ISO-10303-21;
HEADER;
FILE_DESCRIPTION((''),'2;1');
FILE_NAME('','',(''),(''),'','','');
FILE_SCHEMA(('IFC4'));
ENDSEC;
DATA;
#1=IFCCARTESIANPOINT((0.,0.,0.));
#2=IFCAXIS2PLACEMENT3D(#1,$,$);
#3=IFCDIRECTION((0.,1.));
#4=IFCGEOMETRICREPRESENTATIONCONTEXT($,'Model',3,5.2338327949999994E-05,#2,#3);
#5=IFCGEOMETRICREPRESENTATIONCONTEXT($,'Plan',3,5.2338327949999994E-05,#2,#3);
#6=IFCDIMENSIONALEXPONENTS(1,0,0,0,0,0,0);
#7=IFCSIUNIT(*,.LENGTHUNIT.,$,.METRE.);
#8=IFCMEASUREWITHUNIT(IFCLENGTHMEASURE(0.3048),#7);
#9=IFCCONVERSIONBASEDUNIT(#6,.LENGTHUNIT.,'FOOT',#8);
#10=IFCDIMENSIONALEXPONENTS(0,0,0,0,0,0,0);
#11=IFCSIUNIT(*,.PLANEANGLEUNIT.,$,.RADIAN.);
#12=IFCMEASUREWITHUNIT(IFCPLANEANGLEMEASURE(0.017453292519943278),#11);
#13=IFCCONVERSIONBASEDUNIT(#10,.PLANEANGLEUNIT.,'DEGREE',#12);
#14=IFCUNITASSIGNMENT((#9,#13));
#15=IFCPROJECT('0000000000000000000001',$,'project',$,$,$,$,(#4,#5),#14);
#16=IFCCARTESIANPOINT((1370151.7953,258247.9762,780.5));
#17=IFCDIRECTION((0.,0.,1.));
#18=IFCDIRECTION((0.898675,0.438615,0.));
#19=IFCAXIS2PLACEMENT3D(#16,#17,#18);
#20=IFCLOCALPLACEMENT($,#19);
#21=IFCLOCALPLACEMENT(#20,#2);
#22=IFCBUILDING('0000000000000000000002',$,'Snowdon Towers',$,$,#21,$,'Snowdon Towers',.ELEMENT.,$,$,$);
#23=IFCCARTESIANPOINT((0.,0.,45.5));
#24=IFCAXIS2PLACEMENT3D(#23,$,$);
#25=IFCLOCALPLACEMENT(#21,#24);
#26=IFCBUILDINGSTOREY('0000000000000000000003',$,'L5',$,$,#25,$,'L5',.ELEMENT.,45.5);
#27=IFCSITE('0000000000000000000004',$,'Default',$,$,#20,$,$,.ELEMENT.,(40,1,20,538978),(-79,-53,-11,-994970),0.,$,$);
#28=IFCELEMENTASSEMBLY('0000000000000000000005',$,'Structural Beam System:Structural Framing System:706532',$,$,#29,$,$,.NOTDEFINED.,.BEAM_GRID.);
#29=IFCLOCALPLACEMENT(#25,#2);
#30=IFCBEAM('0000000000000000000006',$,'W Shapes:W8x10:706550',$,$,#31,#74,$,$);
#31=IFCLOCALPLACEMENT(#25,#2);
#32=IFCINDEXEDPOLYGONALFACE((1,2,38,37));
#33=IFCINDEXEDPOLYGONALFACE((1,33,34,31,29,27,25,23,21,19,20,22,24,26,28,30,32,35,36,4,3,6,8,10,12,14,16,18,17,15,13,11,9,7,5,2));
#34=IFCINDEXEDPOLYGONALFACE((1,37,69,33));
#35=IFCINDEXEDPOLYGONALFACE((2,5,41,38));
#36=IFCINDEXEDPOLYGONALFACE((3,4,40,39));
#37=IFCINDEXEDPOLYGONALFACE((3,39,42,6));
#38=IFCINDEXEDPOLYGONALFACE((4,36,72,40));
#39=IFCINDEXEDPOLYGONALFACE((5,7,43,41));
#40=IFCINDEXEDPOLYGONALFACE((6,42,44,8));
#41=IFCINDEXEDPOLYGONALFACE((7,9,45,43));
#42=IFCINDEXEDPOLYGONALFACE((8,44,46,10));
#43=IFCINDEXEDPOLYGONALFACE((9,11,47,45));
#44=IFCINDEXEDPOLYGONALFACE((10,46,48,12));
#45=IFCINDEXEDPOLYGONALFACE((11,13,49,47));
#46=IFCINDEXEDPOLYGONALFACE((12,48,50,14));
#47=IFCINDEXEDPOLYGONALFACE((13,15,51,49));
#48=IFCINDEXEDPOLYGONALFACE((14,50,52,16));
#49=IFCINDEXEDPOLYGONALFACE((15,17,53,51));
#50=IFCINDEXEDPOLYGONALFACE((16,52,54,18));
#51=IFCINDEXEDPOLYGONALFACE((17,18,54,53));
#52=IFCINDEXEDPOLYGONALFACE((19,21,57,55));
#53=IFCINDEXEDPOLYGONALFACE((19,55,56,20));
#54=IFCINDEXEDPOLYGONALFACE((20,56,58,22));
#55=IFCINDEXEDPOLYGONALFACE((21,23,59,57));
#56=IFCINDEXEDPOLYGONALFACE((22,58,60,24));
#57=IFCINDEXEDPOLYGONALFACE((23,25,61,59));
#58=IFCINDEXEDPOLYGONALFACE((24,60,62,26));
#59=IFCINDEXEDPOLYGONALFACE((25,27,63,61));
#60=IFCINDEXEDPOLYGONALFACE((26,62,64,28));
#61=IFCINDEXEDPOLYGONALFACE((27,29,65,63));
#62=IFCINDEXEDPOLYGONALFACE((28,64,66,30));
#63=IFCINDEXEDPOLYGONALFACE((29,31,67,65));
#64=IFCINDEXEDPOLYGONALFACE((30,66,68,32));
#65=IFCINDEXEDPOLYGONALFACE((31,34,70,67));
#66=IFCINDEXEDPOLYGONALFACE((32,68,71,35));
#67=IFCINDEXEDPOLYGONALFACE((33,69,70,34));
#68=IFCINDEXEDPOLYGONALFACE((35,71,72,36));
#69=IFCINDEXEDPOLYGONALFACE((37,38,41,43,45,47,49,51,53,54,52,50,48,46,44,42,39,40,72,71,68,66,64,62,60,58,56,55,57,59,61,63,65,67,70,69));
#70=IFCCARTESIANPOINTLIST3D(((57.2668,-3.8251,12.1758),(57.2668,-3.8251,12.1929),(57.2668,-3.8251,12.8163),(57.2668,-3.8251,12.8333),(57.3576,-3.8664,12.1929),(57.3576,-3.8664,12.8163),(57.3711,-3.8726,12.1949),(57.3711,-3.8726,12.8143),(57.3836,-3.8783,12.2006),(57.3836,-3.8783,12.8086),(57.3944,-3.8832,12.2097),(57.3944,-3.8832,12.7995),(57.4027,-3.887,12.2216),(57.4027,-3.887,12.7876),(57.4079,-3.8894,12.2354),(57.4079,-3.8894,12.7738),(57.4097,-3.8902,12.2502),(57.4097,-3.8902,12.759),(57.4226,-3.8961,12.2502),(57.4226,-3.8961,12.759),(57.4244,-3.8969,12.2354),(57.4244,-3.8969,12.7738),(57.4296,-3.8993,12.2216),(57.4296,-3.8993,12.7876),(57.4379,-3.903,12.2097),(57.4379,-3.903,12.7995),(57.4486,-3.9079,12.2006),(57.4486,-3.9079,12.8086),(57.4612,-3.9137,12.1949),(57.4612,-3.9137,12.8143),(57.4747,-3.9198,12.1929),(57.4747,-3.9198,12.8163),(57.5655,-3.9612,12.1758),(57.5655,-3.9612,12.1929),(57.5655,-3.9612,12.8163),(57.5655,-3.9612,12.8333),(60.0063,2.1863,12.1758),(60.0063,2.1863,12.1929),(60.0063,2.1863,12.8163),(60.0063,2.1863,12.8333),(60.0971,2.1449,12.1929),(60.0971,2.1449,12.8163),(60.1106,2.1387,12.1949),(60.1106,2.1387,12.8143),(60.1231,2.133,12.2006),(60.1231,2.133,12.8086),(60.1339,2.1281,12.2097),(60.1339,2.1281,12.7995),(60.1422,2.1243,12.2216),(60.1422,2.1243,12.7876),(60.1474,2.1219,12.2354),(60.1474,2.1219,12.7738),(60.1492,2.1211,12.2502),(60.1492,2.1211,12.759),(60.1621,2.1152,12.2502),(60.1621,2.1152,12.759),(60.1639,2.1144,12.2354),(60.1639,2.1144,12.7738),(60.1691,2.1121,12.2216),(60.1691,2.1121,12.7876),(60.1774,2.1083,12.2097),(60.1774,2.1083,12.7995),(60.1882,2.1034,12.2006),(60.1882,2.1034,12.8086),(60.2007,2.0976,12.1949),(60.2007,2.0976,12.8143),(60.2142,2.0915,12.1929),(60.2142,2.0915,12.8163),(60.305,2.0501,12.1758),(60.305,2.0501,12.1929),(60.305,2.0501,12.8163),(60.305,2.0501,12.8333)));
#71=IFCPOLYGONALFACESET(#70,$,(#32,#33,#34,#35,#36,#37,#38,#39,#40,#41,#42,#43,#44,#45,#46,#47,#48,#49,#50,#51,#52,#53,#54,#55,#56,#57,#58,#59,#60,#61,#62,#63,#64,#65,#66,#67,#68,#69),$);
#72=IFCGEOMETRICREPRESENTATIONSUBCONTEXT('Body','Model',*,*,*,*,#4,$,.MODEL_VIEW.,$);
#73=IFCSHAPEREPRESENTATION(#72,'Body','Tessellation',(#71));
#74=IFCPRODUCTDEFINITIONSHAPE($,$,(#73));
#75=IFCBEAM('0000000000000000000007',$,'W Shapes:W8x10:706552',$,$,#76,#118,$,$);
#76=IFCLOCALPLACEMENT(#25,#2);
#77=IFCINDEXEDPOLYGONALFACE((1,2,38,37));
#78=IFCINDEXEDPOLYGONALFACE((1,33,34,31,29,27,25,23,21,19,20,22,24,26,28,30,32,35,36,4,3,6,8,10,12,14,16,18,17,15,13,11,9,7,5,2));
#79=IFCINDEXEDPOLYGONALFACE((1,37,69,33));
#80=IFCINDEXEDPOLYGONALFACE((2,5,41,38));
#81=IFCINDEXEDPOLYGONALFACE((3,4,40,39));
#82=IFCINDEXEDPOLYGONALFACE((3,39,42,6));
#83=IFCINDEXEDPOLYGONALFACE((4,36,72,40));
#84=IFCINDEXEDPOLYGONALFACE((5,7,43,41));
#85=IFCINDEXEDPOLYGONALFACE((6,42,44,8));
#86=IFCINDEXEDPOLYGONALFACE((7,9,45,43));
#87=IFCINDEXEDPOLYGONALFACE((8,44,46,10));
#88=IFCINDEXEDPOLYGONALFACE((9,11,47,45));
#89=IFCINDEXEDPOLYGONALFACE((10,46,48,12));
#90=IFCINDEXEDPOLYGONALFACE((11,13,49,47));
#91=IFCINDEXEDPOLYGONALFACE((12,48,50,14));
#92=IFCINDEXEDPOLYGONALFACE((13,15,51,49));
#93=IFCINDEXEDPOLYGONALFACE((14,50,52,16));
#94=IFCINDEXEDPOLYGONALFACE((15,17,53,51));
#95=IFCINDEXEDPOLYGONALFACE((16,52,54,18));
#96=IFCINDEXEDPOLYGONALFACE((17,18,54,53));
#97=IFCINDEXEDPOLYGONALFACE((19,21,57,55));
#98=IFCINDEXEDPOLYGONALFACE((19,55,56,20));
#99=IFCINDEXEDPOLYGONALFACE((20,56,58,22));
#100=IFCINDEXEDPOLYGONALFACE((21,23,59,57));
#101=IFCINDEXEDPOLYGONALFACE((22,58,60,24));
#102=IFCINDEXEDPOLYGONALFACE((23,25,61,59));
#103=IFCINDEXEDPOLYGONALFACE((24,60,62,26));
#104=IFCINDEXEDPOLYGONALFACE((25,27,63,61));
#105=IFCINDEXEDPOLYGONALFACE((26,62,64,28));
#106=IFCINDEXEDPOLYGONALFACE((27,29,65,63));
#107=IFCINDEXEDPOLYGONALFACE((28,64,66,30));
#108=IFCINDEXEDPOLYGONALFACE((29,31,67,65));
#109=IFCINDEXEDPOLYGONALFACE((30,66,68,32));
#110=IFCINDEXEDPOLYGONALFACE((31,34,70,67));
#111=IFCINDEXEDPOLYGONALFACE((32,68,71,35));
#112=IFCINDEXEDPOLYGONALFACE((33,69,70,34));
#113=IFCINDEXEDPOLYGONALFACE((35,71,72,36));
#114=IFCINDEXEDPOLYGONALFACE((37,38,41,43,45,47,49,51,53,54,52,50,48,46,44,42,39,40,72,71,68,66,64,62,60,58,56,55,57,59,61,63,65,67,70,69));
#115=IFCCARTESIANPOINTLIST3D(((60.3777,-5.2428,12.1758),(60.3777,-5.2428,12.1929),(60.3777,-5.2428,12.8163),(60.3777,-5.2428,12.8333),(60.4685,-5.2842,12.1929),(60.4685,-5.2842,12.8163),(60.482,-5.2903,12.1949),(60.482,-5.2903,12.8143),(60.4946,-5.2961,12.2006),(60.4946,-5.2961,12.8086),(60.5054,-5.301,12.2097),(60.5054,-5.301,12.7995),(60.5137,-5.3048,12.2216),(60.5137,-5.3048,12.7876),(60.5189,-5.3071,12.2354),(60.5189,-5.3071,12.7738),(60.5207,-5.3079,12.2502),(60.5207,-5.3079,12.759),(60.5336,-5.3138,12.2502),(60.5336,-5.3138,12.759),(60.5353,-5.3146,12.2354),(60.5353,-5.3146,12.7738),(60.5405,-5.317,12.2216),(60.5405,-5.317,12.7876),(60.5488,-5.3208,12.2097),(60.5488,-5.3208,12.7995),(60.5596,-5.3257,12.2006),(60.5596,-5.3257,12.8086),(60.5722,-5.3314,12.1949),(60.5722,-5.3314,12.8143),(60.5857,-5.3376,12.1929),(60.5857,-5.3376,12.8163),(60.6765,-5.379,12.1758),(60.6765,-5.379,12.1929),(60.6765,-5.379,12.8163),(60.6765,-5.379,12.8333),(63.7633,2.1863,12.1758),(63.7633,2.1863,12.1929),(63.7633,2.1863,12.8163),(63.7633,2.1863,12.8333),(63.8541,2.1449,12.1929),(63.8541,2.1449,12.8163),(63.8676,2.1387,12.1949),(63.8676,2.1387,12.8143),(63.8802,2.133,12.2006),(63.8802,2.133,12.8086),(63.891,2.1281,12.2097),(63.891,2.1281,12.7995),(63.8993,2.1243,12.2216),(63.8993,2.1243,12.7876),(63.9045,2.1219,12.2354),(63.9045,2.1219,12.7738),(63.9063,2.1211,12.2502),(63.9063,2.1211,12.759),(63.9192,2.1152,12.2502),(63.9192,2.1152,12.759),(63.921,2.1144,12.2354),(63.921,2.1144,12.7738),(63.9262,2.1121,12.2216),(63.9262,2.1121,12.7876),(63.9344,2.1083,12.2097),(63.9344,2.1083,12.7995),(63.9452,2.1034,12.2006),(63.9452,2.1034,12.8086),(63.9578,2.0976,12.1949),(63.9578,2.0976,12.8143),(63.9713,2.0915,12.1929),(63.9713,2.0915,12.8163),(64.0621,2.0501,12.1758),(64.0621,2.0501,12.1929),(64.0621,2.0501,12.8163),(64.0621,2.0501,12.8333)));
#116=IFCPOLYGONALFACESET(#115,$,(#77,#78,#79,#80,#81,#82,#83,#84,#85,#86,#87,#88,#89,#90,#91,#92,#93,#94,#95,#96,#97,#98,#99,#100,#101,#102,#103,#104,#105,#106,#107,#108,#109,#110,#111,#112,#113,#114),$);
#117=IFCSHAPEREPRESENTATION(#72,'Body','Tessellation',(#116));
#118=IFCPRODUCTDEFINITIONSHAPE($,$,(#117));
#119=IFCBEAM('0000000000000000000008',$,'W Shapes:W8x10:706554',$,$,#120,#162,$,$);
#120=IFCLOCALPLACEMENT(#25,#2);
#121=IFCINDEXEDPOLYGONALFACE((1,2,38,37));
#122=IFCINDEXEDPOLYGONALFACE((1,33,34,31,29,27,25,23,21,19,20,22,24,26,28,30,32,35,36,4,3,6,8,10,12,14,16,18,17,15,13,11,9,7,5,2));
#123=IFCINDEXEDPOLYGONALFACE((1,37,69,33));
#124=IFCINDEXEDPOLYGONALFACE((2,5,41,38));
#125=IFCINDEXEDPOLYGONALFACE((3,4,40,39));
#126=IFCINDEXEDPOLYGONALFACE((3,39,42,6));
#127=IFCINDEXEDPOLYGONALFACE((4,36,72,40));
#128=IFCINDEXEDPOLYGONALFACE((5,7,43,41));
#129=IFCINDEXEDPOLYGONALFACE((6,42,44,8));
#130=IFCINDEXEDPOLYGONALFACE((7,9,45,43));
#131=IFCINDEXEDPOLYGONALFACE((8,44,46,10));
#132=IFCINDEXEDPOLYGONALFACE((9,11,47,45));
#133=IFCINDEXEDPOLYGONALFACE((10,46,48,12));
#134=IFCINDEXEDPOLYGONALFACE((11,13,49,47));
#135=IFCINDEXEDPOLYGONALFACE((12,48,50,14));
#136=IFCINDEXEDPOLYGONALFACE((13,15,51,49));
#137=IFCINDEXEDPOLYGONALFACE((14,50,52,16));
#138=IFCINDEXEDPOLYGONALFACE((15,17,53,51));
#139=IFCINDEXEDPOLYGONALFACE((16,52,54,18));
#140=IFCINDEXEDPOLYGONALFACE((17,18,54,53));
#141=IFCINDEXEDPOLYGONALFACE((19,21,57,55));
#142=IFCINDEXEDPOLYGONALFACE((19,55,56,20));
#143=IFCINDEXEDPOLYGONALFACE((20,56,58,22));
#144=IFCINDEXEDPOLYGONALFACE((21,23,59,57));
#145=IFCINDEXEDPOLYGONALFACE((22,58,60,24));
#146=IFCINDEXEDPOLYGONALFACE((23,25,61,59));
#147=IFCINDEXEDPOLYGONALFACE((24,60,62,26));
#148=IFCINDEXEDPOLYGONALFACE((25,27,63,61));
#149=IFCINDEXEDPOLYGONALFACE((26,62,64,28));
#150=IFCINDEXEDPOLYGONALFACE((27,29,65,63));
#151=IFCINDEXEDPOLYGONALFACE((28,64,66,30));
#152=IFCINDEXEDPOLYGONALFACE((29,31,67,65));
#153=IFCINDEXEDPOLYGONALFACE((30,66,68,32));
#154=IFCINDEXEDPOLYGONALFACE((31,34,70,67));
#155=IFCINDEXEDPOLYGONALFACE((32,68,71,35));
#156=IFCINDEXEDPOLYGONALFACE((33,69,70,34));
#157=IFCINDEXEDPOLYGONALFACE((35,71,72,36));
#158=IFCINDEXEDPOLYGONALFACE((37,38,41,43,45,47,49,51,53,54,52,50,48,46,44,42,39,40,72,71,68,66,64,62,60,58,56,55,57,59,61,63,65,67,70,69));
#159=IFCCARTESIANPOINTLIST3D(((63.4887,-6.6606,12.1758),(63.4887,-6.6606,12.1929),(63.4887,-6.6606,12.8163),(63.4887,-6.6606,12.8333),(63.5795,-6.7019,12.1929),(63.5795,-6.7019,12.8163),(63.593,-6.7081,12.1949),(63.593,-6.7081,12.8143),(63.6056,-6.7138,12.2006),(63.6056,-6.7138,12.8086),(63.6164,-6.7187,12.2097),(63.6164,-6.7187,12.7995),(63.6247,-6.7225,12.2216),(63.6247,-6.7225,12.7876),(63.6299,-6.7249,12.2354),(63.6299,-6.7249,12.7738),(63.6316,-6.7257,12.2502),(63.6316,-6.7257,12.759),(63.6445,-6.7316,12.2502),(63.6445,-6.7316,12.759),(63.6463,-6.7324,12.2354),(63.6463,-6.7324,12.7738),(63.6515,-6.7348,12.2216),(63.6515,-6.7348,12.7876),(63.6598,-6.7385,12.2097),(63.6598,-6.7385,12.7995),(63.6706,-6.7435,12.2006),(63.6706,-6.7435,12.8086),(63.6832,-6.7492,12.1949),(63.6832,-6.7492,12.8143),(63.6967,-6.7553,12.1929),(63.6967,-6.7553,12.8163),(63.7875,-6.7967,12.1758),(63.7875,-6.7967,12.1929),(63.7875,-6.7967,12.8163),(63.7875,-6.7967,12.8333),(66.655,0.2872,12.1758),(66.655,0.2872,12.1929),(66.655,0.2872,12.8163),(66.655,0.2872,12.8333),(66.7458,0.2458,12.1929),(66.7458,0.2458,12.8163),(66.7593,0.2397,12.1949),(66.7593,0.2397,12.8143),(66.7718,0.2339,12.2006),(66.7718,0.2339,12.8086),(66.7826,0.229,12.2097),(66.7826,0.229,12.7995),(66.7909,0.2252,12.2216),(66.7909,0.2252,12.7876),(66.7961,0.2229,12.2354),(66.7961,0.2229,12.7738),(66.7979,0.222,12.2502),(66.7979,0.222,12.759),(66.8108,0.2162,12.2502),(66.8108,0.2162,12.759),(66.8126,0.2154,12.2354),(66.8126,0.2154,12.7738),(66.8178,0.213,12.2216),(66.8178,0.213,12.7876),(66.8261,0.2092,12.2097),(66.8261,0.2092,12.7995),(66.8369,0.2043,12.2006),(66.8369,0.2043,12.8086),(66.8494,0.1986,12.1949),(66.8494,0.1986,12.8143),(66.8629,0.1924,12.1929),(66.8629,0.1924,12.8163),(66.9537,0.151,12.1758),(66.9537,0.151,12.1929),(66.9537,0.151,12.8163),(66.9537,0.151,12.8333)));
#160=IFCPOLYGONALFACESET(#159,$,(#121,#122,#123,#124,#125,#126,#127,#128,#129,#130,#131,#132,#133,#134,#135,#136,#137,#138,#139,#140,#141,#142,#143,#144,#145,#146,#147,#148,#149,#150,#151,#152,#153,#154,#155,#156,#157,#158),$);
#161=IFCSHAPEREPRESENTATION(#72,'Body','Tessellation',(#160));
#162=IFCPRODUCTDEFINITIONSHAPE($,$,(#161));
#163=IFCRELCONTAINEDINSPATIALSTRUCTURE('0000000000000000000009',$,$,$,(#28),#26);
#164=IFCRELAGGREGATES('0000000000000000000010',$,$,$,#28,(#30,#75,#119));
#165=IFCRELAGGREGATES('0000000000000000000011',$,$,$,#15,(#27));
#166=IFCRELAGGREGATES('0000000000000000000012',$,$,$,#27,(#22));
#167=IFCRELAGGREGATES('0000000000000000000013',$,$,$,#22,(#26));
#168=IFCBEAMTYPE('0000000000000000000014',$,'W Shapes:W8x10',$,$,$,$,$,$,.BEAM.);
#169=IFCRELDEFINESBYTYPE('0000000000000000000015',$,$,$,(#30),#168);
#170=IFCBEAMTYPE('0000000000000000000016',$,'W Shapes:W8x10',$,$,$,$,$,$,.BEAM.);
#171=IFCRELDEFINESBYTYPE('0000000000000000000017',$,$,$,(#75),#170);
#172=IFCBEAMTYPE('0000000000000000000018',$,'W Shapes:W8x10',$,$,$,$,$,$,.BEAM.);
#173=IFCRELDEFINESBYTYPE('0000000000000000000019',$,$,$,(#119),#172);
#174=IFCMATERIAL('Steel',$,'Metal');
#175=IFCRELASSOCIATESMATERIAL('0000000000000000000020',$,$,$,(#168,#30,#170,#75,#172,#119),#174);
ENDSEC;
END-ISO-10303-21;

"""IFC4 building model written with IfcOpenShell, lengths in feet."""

from ifc_helpers import new_model, entity, si_unit, converted_unit, direction, frame, origin, place, context, subcontext, project, spatial, line, arc, indexed_curve, outline, extrude, source, transform, mapped, material, type_object, type_shapes, element, aggregate, save


model = new_model("IFC4")

# Units and contexts
model_context = context("Model", 3, precision=5.2338327949999994e-05, world=origin(), true_north=direction((0.0, 1.0)))
plan_context = context("Plan", 3, precision=5.2338327949999994e-05, world=origin(), true_north=direction((0.0, 1.0)))
body_context = subcontext(model_context, "Body", "Model", "MODEL_VIEW")
ifc_project = project(units=[converted_unit("LENGTHUNIT", "FOOT", entity("IfcLengthMeasure", 0.3048), si_unit("LENGTHUNIT", "METRE"), dimensions=[1, 0, 0, 0, 0, 0, 0]), converted_unit("PLANEANGLEUNIT", "DEGREE", entity("IfcPlaneAngleMeasure", 0.017453292519943278), si_unit("PLANEANGLEUNIT", "RADIAN"), dimensions=[0, 0, 0, 0, 0, 0, 0])], contexts=[model_context, plan_context])

# Site, building, storey
site_placement = place(None, frame((1370151.7953, 258247.9762, 780.5), z_axis=(0.0, 0.0, 1.0), x_axis=(0.898675, 0.438615, 0.0)))
site = spatial("IfcSite", under=ifc_project, at=site_placement, Name="Default", CompositionType="ELEMENT", RefLatitude=(40, 1, 20, 538978), RefLongitude=(-79, -53, -11, -994970), RefElevation=0.0)
building_placement = place(site_placement, origin())
building = spatial("IfcBuilding", under=site, at=building_placement, Name="Snowdon Towers", LongName="Snowdon Towers", CompositionType="ELEMENT")
storey_placement = place(building_placement, frame((0.0, 0.0, 45.5)))
storey = spatial("IfcBuildingStorey", under=building, at=storey_placement, Name="L5", LongName="L5", CompositionType="ELEMENT", Elevation=45.5)

# Shared definitions
ifc_material = material(Name="Steel", Category="Metal")

# Element assembly, beams
assembly_1_placement = place(storey_placement, origin())
assembly_1 = element("IfcElementAssembly", 1, at=assembly_1_placement, inside=storey, Name="Structural Beam System:Structural Framing System:706532", AssemblyPlace="NOTDEFINED", PredefinedType="BEAM_GRID")
beam_type_1 = type_object("IfcBeamType", Name="W Shapes:W8x10", PredefinedType="BEAM", material=ifc_material)
shared_shape_1 = source(origin(), body_context, "Body", "SweptSolid", [
    extrude(outline(indexed_curve([(-0.3287, -0.1642), (-0.3117, -0.1642), (-0.3117, -0.0644), (-0.2949, -0.0239), (-0.2544, -0.0071), (0.2544, -0.0071), (0.2949, -0.0239), (0.3117, -0.0644), (0.3117, -0.1642), (0.3288, -0.1642), (0.3288, 0.1642), (0.3117, 0.1642), (0.3117, 0.0644), (0.2949, 0.0239), (0.2544, 0.0071), (-0.2544, 0.0071), (-0.2949, 0.0239), (-0.3117, 0.0644), (-0.3117, 0.1642), (-0.3287, 0.1642)], segments=[line(1, 2, 3), arc(3, 4, 5), line(5, 6), arc(6, 7, 8), line(8, 9, 10, 11, 12, 13), arc(13, 14, 15), line(15, 16), arc(16, 17, 18), line(18, 19, 20, 1)], self_intersect=False)), frame((-3.3777, 0.0, 0.0), z_axis=(1.0, 0.0, 0.0), x_axis=(0.0, 0.0, -1.0)), (0.0, 0.0, 1.0), 6.6061),
])
type_shapes(beam_type_1, [shared_shape_1])
beam_1_placement = place(assembly_1_placement, frame((58.8168, -0.8196, 12.5046), z_axis=(0.0, 0.0, 1.0), x_axis=(0.414693, 0.909961, 0.0)))
beam_1 = element("IfcBeam", 2, at=beam_1_placement, type_object=beam_type_1, material=ifc_material, Name="W Shapes:W8x10:706550", context=body_context, shape_type="MappedRepresentation", body=[
    mapped(shared_shape_1, transform((0.0, 0.0, 0.0), scale=1.0)),
])
beam_type_2 = type_object("IfcBeamType", Name="W Shapes:W8x10", PredefinedType="BEAM", material=ifc_material)
shared_shape_2 = source(origin(), body_context, "Body", "SweptSolid", [
    extrude(outline(indexed_curve([(-0.3287, -0.1642), (-0.3117, -0.1642), (-0.3117, -0.0644), (-0.2949, -0.0239), (-0.2544, -0.0071), (0.2544, -0.0071), (0.2949, -0.0239), (0.3117, -0.0644), (0.3117, -0.1642), (0.3288, -0.1642), (0.3288, 0.1642), (0.3117, 0.1642), (0.3117, 0.0644), (0.2949, 0.0239), (0.2544, 0.0071), (-0.2544, 0.0071), (-0.2949, 0.0239), (-0.3117, 0.0644), (-0.3117, 0.1642), (-0.3287, 0.1642)], segments=[line(1, 2, 3), arc(3, 4, 5), line(5, 6), arc(6, 7, 8), line(8, 9, 10, 11, 12, 13), arc(13, 14, 15), line(15, 16), arc(16, 17, 18), line(18, 19, 20, 1)], self_intersect=False)), frame((-4.1567, 0.0, 0.0), z_axis=(1.0, 0.0, 0.0), x_axis=(0.0, 0.0, -1.0)), (0.0, 0.0, 1.0), 8.1641),
])
type_shapes(beam_type_2, [shared_shape_2])
beam_2_placement = place(assembly_1_placement, frame((62.2509, -1.5285, 12.5046), z_axis=(0.0, 0.0, 1.0), x_axis=(0.414693, 0.909961, 0.0)))
beam_2 = element("IfcBeam", 3, at=beam_2_placement, type_object=beam_type_2, material=ifc_material, Name="W Shapes:W8x10:706552", context=body_context, shape_type="MappedRepresentation", body=[
    mapped(shared_shape_2, transform((0.0, 0.0, 0.0), scale=1.0)),
])
beam_type_3 = type_object("IfcBeamType", Name="W Shapes:W8x10", PredefinedType="BEAM", material=ifc_material)
shared_shape_3 = source(origin(), body_context, "Body", "SweptSolid", [
    extrude(outline(indexed_curve([(-0.3287, -0.1642), (-0.3117, -0.1642), (-0.3117, -0.0644), (-0.2949, -0.0239), (-0.2544, -0.0071), (0.2544, -0.0071), (0.2949, -0.0239), (0.3117, -0.0644), (0.3117, -0.1642), (0.3288, -0.1642), (0.3288, 0.1642), (0.3117, 0.1642), (0.3117, 0.0644), (0.2949, 0.0239), (0.2544, 0.0071), (-0.2544, 0.0071), (-0.2949, 0.0239), (-0.3117, 0.0644), (-0.3117, 0.1642), (-0.3287, 0.1642)], segments=[line(1, 2, 3), arc(3, 4, 5), line(5, 6), arc(6, 7, 8), line(8, 9, 10, 11, 12, 13), arc(13, 14, 15), line(15, 16), arc(16, 17, 18), line(18, 19, 20, 1)], self_intersect=False)), frame((-4.1098, 0.0, 0.0), z_axis=(1.0, 0.0, 0.0), x_axis=(0.0, 0.0, -1.0)), (0.0, 0.0, 1.0), 7.6352),
])
type_shapes(beam_type_3, [shared_shape_3])
beam_3_placement = place(assembly_1_placement, frame((65.3424, -2.9889, 12.5046), z_axis=(0.0, 0.0, 1.0), x_axis=(0.414693, 0.909961, 0.0)))
beam_3 = element("IfcBeam", 4, at=beam_3_placement, type_object=beam_type_3, material=ifc_material, Name="W Shapes:W8x10:706554", context=body_context, shape_type="MappedRepresentation", body=[
    mapped(shared_shape_3, transform((0.0, 0.0, 0.0), scale=1.0)),
])
aggregate(assembly_1, [beam_1, beam_2, beam_3])

save(model, "model.ifc")
